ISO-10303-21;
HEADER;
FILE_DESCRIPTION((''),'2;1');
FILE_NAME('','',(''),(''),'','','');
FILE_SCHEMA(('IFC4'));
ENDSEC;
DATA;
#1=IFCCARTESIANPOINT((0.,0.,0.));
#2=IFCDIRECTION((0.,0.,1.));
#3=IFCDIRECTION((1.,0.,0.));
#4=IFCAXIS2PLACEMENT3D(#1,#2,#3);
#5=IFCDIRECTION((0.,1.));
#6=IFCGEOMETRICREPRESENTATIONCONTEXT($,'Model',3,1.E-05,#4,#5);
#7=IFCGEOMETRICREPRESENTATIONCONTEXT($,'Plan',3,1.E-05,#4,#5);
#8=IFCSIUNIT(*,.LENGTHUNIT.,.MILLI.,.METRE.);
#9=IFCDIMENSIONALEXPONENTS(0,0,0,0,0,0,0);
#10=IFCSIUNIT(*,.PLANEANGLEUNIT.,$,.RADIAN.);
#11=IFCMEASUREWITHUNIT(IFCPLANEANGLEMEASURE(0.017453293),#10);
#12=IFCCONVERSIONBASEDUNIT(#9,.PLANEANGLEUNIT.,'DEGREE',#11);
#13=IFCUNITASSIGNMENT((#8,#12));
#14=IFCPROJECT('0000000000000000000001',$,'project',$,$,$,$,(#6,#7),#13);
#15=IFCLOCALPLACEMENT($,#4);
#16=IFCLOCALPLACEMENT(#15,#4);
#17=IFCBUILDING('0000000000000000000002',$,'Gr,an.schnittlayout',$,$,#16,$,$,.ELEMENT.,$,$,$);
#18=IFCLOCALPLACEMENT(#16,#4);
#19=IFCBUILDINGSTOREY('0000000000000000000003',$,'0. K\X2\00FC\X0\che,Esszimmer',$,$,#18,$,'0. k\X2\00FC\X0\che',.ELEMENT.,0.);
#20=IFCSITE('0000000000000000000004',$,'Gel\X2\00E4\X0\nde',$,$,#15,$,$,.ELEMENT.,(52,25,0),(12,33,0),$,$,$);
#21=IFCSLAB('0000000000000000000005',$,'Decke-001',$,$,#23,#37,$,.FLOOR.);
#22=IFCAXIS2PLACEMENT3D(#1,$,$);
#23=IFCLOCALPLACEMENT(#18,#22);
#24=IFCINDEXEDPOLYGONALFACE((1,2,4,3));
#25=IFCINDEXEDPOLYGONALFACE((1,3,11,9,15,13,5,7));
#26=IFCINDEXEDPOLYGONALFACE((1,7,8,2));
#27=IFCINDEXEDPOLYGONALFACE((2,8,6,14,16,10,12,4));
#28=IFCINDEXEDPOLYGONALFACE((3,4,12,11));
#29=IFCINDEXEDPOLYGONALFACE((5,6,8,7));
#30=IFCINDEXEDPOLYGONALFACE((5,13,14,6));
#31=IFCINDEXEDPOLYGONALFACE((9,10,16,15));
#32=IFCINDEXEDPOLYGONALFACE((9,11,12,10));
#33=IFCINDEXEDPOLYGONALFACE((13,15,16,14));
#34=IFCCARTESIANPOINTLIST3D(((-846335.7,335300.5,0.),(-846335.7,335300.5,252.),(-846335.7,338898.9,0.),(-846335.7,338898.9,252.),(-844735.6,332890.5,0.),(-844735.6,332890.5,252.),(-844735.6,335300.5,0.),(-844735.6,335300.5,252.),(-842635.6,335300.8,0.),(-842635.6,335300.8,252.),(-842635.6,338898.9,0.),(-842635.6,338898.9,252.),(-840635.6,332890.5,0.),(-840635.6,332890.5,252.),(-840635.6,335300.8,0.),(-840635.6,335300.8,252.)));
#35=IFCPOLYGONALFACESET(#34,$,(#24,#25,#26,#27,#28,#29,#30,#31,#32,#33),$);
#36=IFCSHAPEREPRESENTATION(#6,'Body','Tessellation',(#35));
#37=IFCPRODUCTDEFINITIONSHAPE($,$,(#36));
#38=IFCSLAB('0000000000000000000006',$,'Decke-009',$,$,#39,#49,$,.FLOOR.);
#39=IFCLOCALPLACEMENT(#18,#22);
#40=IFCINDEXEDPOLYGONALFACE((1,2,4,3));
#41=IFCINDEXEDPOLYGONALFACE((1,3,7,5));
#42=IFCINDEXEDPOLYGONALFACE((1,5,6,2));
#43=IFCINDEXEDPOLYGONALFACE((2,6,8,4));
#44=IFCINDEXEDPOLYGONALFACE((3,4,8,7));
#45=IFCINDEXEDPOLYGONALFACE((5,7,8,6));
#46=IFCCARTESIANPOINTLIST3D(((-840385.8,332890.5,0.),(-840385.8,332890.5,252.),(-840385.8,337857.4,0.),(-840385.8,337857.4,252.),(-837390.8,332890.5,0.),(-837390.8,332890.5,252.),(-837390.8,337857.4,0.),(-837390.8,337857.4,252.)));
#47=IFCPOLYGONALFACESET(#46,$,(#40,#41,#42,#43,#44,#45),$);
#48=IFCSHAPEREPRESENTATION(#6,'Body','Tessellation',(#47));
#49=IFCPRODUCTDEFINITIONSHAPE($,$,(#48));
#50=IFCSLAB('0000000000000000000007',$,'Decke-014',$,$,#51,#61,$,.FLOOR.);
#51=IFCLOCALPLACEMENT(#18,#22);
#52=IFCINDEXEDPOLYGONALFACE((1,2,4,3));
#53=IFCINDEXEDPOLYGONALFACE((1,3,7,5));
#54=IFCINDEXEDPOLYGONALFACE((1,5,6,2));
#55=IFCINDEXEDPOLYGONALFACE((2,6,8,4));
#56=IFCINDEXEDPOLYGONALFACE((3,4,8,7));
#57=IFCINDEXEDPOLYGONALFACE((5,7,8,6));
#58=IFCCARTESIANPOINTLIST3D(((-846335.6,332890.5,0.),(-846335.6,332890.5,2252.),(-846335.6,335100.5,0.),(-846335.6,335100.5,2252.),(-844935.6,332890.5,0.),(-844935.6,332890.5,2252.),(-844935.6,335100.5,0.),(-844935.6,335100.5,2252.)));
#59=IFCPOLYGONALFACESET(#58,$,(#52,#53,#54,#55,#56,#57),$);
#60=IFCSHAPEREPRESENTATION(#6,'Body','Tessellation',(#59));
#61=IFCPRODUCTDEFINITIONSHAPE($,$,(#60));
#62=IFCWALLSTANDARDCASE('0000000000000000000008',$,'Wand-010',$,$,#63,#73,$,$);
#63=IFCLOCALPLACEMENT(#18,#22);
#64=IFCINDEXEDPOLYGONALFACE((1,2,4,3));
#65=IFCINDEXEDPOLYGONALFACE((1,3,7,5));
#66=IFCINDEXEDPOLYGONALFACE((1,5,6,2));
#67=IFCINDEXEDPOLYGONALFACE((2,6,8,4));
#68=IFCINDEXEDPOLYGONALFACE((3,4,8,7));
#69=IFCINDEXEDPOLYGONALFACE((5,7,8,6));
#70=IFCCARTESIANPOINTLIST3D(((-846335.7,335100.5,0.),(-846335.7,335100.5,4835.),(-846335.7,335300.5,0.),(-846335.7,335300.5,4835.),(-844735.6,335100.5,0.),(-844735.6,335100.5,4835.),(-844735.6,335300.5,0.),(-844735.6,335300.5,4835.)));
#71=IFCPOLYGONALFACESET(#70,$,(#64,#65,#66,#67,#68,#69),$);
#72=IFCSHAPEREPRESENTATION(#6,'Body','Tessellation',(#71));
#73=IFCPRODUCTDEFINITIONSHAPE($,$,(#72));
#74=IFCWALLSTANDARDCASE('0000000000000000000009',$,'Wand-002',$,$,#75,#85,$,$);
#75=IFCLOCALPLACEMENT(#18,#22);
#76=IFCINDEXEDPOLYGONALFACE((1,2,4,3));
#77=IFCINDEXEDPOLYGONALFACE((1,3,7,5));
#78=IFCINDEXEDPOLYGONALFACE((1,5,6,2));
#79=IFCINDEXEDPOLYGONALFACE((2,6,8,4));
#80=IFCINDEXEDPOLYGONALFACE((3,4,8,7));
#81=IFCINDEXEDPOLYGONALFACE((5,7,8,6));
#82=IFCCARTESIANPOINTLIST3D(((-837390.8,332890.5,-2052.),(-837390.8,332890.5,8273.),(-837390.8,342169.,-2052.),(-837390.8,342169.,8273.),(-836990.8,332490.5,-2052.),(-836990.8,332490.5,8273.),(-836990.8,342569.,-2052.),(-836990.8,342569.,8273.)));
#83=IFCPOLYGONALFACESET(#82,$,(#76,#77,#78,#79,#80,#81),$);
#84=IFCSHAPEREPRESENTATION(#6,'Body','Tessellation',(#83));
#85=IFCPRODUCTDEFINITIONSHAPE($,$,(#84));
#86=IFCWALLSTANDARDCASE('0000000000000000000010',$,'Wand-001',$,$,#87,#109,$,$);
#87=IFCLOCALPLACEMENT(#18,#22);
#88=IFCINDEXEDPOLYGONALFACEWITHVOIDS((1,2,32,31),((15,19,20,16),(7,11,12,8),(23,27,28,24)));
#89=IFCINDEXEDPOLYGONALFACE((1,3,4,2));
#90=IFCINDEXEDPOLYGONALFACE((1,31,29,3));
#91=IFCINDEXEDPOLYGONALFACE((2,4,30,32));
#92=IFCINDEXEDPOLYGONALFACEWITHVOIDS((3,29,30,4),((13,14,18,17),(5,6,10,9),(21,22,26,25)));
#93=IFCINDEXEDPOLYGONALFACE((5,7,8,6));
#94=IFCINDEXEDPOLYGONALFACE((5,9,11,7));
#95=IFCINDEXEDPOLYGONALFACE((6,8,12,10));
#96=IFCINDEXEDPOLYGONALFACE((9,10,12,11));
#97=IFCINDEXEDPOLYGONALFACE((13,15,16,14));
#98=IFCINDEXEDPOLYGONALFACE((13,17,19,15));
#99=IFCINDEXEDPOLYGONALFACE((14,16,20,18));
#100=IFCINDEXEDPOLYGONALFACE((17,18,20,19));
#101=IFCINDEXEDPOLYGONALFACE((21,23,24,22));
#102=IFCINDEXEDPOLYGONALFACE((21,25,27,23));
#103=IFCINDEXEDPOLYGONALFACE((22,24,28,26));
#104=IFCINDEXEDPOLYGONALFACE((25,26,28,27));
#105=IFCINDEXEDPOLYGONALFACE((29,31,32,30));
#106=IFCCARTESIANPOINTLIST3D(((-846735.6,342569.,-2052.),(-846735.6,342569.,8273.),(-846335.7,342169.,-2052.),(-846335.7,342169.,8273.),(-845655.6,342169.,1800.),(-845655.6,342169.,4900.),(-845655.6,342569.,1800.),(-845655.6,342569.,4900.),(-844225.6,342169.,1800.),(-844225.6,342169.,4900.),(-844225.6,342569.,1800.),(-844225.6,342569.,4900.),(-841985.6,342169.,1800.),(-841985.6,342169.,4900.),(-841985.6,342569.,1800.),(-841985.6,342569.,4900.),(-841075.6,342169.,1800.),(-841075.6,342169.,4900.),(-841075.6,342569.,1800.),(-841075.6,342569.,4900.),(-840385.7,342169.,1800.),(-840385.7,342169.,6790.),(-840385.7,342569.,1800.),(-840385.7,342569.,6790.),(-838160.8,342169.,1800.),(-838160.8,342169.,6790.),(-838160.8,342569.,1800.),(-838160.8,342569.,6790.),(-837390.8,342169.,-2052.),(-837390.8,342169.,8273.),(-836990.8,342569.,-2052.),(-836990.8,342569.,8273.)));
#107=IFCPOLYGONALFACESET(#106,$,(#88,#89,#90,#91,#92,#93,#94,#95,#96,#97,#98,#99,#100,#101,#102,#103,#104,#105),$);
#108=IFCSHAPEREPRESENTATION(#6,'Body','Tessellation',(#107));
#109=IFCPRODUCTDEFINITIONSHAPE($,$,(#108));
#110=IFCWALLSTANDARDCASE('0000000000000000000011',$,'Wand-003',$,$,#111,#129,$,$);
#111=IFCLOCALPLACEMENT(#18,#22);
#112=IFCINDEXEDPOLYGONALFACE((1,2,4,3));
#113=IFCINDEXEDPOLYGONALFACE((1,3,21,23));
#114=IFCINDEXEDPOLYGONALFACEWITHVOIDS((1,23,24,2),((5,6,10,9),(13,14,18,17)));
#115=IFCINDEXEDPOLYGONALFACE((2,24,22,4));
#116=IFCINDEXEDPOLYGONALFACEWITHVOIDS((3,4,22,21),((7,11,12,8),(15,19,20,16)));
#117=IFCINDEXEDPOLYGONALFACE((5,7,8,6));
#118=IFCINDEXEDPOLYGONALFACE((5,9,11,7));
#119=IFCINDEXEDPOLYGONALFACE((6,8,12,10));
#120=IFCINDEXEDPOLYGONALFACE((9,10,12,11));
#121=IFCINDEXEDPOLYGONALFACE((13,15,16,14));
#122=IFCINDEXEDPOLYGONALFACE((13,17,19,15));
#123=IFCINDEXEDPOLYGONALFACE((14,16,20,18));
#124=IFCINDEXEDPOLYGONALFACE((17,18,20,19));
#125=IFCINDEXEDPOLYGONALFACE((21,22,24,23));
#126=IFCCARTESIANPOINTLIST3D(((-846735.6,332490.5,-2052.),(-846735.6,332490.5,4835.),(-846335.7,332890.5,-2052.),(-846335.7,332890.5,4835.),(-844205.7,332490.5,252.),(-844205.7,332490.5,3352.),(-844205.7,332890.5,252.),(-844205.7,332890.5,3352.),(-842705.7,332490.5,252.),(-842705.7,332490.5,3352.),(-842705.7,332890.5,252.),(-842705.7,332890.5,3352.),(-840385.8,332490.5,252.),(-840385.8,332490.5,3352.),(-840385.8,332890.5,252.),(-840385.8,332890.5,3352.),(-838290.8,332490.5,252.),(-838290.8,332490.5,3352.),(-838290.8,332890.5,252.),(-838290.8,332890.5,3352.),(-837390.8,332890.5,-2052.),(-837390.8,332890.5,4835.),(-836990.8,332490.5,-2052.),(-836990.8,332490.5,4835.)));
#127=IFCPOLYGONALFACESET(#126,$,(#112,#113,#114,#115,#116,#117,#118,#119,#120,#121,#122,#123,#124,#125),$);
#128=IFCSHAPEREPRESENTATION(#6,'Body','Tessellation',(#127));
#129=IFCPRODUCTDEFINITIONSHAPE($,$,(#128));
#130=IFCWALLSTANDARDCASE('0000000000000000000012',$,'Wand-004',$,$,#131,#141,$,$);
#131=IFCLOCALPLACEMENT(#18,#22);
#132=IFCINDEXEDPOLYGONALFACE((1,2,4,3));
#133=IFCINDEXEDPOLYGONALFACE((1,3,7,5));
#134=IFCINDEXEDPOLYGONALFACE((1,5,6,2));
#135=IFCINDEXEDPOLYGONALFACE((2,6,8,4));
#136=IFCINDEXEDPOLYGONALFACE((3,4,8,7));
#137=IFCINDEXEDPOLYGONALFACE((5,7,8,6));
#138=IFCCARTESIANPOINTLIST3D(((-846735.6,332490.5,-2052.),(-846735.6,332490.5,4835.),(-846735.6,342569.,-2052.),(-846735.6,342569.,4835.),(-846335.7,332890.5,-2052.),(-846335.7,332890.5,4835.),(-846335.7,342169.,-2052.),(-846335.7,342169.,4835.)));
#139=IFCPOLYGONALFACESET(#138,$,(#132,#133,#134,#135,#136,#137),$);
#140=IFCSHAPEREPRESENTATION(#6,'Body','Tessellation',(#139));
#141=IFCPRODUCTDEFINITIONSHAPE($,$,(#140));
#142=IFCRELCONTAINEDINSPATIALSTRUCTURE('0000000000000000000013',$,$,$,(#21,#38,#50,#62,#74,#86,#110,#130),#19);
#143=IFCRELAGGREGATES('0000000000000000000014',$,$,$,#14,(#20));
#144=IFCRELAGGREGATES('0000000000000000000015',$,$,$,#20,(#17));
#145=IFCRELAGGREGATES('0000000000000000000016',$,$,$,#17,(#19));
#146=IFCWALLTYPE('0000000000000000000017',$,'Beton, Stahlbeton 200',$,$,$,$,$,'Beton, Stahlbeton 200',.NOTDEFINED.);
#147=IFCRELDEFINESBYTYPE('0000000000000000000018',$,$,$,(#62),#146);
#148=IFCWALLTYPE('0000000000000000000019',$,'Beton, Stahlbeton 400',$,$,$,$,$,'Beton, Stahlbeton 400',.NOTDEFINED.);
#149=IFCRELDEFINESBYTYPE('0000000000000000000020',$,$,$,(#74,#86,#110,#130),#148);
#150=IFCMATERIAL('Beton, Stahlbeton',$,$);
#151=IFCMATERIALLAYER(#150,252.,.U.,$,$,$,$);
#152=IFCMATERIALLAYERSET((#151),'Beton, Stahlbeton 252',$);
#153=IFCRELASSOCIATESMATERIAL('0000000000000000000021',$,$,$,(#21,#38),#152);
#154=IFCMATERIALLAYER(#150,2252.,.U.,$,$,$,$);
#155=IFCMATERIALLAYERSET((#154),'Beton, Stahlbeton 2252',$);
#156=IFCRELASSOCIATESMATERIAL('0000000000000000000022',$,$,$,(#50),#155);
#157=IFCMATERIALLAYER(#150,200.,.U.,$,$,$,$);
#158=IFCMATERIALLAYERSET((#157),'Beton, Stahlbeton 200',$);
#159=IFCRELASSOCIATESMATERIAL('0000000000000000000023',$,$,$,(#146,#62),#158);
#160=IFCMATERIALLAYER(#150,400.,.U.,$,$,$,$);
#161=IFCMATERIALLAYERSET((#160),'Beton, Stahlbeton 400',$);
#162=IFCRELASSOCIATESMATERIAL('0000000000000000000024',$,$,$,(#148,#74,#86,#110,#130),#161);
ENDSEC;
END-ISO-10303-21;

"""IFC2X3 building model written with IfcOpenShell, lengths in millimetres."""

from ifc_helpers import new_model, entity, si_unit, converted_unit, direction, frame, frame_2d, origin_with_axes, place, context, project, spatial, polyline, rectangle, outline, extrude, material, layer, layer_set, layer_usage, type_object, element, save


model = new_model("IFC2X3")

# Units and contexts
model_context = context("Model", 3, precision=1e-05, world=origin_with_axes(), true_north=direction((0.0, 1.0)))
plan_context = context("Plan", 3, precision=1e-05, world=origin_with_axes(), true_north=direction((0.0, 1.0)))
ifc_project = project(units=[si_unit("LENGTHUNIT", "METRE", prefix="MILLI"), converted_unit("PLANEANGLEUNIT", "DEGREE", entity("IfcPlaneAngleMeasure", 0.017453293), si_unit("PLANEANGLEUNIT", "RADIAN"), dimensions=[0, 0, 0, 0, 0, 0, 0])], contexts=[model_context, plan_context])

# Site, building, storey
site_placement = place(None, origin_with_axes())
site = spatial("IfcSite", under=ifc_project, at=site_placement, Name="Gelände", CompositionType="ELEMENT", RefLatitude=(52, 25, 0), RefLongitude=(12, 33, 0))
building_placement = place(site_placement, origin_with_axes())
building = spatial("IfcBuilding", under=site, at=building_placement, Name="Gr,an.schnittlayout", CompositionType="ELEMENT")
storey_placement = place(building_placement, origin_with_axes())
storey = spatial("IfcBuildingStorey", under=building, at=storey_placement, Name="0. Küche,Esszimmer", LongName="0. küche", CompositionType="ELEMENT", Elevation=0.0)

# Slabs
ifc_material = material(Name="Beton, Stahlbeton")
ifc_layer_1 = layer(ifc_material, 252.0, ventilated="UNKNOWN")
ifc_layer_set_1 = layer_set([ifc_layer_1], Name="Beton, Stahlbeton 252")
ifc_layer_usage_1 = layer_usage(ifc_layer_set_1, "AXIS3", "NEGATIVE", 252.0)
slab_1_placement = place(storey_placement, frame((-840635.7, 332890.5, 0.0), z_axis=(0.0, 0.0, 1.0), x_axis=(0.0, 1.0, 0.0)))
element("IfcSlab", 1, at=slab_1_placement, inside=storey, material=ifc_layer_usage_1, Name="Decke-001", PredefinedType="FLOOR", context=model_context, shape_type="SweptSolid", body=[
    extrude(outline(polyline([(0.0, 0.0), (2410.3, 0.0), (2410.3, 2000.0), (6008.4, 2000.0), (6008.4, 5700.0), (2410.0, 5700.0), (2410.0, 4100.0), (0.0, 4100.0), (0.0, 0.0)])), origin_with_axes(), (0.0, 0.0, 1.0), 252.0),
])
ifc_layer_usage_2 = layer_usage(ifc_layer_set_1, "AXIS3", "NEGATIVE", 252.0)
slab_2_placement = place(storey_placement, frame((-837390.8, 332890.5, 0.0), z_axis=(0.0, 0.0, 1.0), x_axis=(-1.0, 0.0, 0.0)))
element("IfcSlab", 2, at=slab_2_placement, inside=storey, material=ifc_layer_usage_2, Name="Decke-009", PredefinedType="FLOOR", context=model_context, shape_type="SweptSolid", body=[
    extrude(outline(polyline([(0.0, 0.0), (2995.0, 0.0), (2995.0, -4966.9), (0.0, -4966.9), (0.0, 0.0)])), origin_with_axes(), (0.0, 0.0, 1.0), 252.0),
])
ifc_layer_2 = layer(ifc_material, 2252.0, ventilated="UNKNOWN")
ifc_layer_set_2 = layer_set([ifc_layer_2], Name="Beton, Stahlbeton 2252")
ifc_layer_usage_3 = layer_usage(ifc_layer_set_2, "AXIS3", "NEGATIVE", 2252.0)
slab_3_placement = place(storey_placement, frame((-846335.7, 335100.5, 0.0), z_axis=(0.0, 0.0, 1.0), x_axis=(1.0, 0.0, 0.0)))
element("IfcSlab", 3, at=slab_3_placement, inside=storey, material=ifc_layer_usage_3, Name="Decke-014", PredefinedType="FLOOR", context=model_context, shape_type="SweptSolid", body=[
    extrude(outline(polyline([(0.0, 0.0), (1400.0, 0.0), (1400.0, -2210.0), (0.0, -2210.0), (0.0, 0.0)])), origin_with_axes(), (0.0, 0.0, 1.0), 2252.0),
])

# Wall
ifc_layer_3 = layer(ifc_material, 200.0, ventilated="UNKNOWN")
ifc_layer_set_3 = layer_set([ifc_layer_3], Name="Beton, Stahlbeton 200")
ifc_layer_usage_4 = layer_usage(ifc_layer_set_3, "AXIS2", "NEGATIVE", 0.0)
wall_type_1 = type_object("IfcWallType", Name="Beton, Stahlbeton 200", ElementType="Beton, Stahlbeton 200", PredefinedType="NOTDEFINED", material=ifc_layer_set_3)
wall_1_placement = place(storey_placement, frame((-844735.7, 335100.5, 0.0), z_axis=(0.0, 0.0, 1.0), x_axis=(-1.0, 0.0, 0.0)))
element("IfcWallStandardCase", 4, at=wall_1_placement, inside=storey, type_object=wall_type_1, material=ifc_layer_usage_4, Name="Wand-010", context=model_context, shape_type="SweptSolid", body=[
    extrude(outline(polyline([(0.0, -200.0), (1600.0, -200.0), (1600.0, 0.0), (0.0, 0.0), (0.0, -200.0)])), origin_with_axes(), (0.0, 0.0, 1.0), 4835.0),
])

# Wall
ifc_layer_4 = layer(ifc_material, 400.0, ventilated="UNKNOWN")
ifc_layer_set_4 = layer_set([ifc_layer_4], Name="Beton, Stahlbeton 400")
ifc_layer_usage_5 = layer_usage(ifc_layer_set_4, "AXIS2", "NEGATIVE", 0.0)
wall_type_2 = type_object("IfcWallType", Name="Beton, Stahlbeton 400", ElementType="Beton, Stahlbeton 400", PredefinedType="NOTDEFINED", material=ifc_layer_set_4)
wall_2_placement = place(storey_placement, frame((-836990.8, 342569.0, -2052.0), z_axis=(0.0, 0.0, 1.0), x_axis=(0.0, -1.0, 0.0)))
element("IfcWallStandardCase", 5, at=wall_2_placement, inside=storey, type_object=wall_type_2, material=ifc_layer_usage_5, Name="Wand-002", context=model_context, shape_type="SweptSolid", body=[
    extrude(outline(polyline([(400.0, -400.0), (9678.5, -400.0), (10078.5, 0.0), (0.0, 0.0), (400.0, -400.0)])), origin_with_axes(), (0.0, 0.0, 1.0), 10325.0),
])

# Walls, openings
ifc_layer_usage_6 = layer_usage(ifc_layer_set_4, "AXIS2", "NEGATIVE", 0.0)
wall_3_placement = place(storey_placement, frame((-846735.7, 342569.0, -2052.0), z_axis=(0.0, 0.0, 1.0), x_axis=(1.0, 0.0, 0.0)))
wall_3 = element("IfcWallStandardCase", 6, at=wall_3_placement, inside=storey, type_object=wall_type_2, material=ifc_layer_usage_6, Name="Wand-001", context=model_context, shape_type="SweptSolid", body=[
    extrude(outline(polyline([(400.0, -400.0), (9344.9, -400.0), (9744.9, 0.0), (0.0, 0.0), (400.0, -400.0)])), origin_with_axes(), (0.0, 0.0, 1.0), 10325.0),
])
opening_1_placement = place(wall_3_placement, frame((5205.0, -400.0, 3852.0), z_axis=(0.0, 0.0, 1.0), x_axis=(1.0, 0.0, 0.0)))
element("IfcOpeningElement", 7, at=opening_1_placement, cuts=wall_3, ObjectType="Opening", context=model_context, shape_type="SweptSolid", body=[
    extrude(rectangle(XDim=910.0, YDim=3100.0, at=frame_2d((0.0, 1550.0), x_axis=(-1.0, 0.0))), frame((0.0, 0.0, 0.0), z_axis=(0.0, 1.0, 0.0), x_axis=(-1.0, 0.0, 0.0)), (0.0, 0.0, 1.0), 400.0),
])
opening_2_placement = place(wall_3_placement, frame((7462.4, -400.0, 3852.0), z_axis=(0.0, 0.0, 1.0), x_axis=(1.0, 0.0, 0.0)))
element("IfcOpeningElement", 8, at=opening_2_placement, cuts=wall_3, ObjectType="Opening", context=model_context, shape_type="SweptSolid", body=[
    extrude(rectangle(XDim=2224.9, YDim=4990.0, at=frame_2d((0.0, 2495.0), x_axis=(1.0, 0.0))), frame((0.0, 0.0, 0.0), z_axis=(0.0, 1.0, 0.0), x_axis=(-1.0, 0.0, 0.0)), (0.0, 0.0, 1.0), 400.0),
])
opening_3_placement = place(wall_3_placement, frame((1795.0, -400.0, 3852.0), z_axis=(0.0, 0.0, 1.0), x_axis=(1.0, 0.0, 0.0)))
element("IfcOpeningElement", 9, at=opening_3_placement, cuts=wall_3, ObjectType="Opening", context=model_context, shape_type="SweptSolid", body=[
    extrude(rectangle(XDim=1430.0, YDim=3100.0, at=frame_2d((0.0, 1550.0), x_axis=(1.0, 0.0))), frame((0.0, 0.0, 0.0), z_axis=(0.0, 1.0, 0.0), x_axis=(-1.0, 0.0, 0.0)), (0.0, 0.0, 1.0), 400.0),
])
ifc_layer_usage_7 = layer_usage(ifc_layer_set_4, "AXIS2", "NEGATIVE", 0.0)
wall_4_placement = place(storey_placement, frame((-836990.8, 332490.5, -2052.0), z_axis=(0.0, 0.0, 1.0), x_axis=(-1.0, 0.0, 0.0)))
wall_4 = element("IfcWallStandardCase", 10, at=wall_4_placement, inside=storey, type_object=wall_type_2, material=ifc_layer_usage_7, Name="Wand-003", context=model_context, shape_type="SweptSolid", body=[
    extrude(outline(polyline([(400.0, -400.0), (9344.9, -400.0), (9744.9, 0.0), (0.0, 0.0), (400.0, -400.0)])), origin_with_axes(), (0.0, 0.0, 1.0), 6887.0),
])
opening_4_placement = place(wall_4_placement, frame((2347.5, -400.0, 2304.0), z_axis=(0.0, 0.0, 1.0), x_axis=(1.0, 0.0, 0.0)))
element("IfcOpeningElement", 11, at=opening_4_placement, cuts=wall_4, ObjectType="Opening", context=model_context, shape_type="SweptSolid", body=[
    extrude(rectangle(XDim=2095.0, YDim=3100.0, at=frame_2d((0.0, 1550.0), x_axis=(1.0, 0.0))), frame((0.0, 0.0, 0.0), z_axis=(0.0, 1.0, 0.0), x_axis=(-1.0, 0.0, 0.0)), (0.0, 0.0, 1.0), 400.0),
])
opening_5_placement = place(wall_4_placement, frame((6464.9, -400.0, 2304.0), z_axis=(0.0, 0.0, 1.0), x_axis=(1.0, 0.0, 0.0)))
element("IfcOpeningElement", 12, at=opening_5_placement, cuts=wall_4, ObjectType="Opening", context=model_context, shape_type="SweptSolid", body=[
    extrude(rectangle(XDim=1500.0, YDim=3100.0, at=frame_2d((0.0, 1550.0), x_axis=(-1.0, 0.0))), frame((0.0, 0.0, 0.0), z_axis=(0.0, 1.0, 0.0), x_axis=(-1.0, 0.0, 0.0)), (0.0, 0.0, 1.0), 400.0),
])

# Wall
ifc_layer_usage_8 = layer_usage(ifc_layer_set_4, "AXIS2", "NEGATIVE", 0.0)
wall_5_placement = place(storey_placement, frame((-846735.7, 332490.5, -2052.0), z_axis=(0.0, 0.0, 1.0), x_axis=(0.0, 1.0, 0.0)))
element("IfcWallStandardCase", 13, at=wall_5_placement, inside=storey, type_object=wall_type_2, material=ifc_layer_usage_8, Name="Wand-004", context=model_context, shape_type="SweptSolid", body=[
    extrude(outline(polyline([(400.0, -400.0), (9678.5, -400.0), (10078.5, 0.0), (0.0, 0.0), (400.0, -400.0)])), origin_with_axes(), (0.0, 0.0, 1.0), 6887.0),
])

save(model, "model.ifc")
